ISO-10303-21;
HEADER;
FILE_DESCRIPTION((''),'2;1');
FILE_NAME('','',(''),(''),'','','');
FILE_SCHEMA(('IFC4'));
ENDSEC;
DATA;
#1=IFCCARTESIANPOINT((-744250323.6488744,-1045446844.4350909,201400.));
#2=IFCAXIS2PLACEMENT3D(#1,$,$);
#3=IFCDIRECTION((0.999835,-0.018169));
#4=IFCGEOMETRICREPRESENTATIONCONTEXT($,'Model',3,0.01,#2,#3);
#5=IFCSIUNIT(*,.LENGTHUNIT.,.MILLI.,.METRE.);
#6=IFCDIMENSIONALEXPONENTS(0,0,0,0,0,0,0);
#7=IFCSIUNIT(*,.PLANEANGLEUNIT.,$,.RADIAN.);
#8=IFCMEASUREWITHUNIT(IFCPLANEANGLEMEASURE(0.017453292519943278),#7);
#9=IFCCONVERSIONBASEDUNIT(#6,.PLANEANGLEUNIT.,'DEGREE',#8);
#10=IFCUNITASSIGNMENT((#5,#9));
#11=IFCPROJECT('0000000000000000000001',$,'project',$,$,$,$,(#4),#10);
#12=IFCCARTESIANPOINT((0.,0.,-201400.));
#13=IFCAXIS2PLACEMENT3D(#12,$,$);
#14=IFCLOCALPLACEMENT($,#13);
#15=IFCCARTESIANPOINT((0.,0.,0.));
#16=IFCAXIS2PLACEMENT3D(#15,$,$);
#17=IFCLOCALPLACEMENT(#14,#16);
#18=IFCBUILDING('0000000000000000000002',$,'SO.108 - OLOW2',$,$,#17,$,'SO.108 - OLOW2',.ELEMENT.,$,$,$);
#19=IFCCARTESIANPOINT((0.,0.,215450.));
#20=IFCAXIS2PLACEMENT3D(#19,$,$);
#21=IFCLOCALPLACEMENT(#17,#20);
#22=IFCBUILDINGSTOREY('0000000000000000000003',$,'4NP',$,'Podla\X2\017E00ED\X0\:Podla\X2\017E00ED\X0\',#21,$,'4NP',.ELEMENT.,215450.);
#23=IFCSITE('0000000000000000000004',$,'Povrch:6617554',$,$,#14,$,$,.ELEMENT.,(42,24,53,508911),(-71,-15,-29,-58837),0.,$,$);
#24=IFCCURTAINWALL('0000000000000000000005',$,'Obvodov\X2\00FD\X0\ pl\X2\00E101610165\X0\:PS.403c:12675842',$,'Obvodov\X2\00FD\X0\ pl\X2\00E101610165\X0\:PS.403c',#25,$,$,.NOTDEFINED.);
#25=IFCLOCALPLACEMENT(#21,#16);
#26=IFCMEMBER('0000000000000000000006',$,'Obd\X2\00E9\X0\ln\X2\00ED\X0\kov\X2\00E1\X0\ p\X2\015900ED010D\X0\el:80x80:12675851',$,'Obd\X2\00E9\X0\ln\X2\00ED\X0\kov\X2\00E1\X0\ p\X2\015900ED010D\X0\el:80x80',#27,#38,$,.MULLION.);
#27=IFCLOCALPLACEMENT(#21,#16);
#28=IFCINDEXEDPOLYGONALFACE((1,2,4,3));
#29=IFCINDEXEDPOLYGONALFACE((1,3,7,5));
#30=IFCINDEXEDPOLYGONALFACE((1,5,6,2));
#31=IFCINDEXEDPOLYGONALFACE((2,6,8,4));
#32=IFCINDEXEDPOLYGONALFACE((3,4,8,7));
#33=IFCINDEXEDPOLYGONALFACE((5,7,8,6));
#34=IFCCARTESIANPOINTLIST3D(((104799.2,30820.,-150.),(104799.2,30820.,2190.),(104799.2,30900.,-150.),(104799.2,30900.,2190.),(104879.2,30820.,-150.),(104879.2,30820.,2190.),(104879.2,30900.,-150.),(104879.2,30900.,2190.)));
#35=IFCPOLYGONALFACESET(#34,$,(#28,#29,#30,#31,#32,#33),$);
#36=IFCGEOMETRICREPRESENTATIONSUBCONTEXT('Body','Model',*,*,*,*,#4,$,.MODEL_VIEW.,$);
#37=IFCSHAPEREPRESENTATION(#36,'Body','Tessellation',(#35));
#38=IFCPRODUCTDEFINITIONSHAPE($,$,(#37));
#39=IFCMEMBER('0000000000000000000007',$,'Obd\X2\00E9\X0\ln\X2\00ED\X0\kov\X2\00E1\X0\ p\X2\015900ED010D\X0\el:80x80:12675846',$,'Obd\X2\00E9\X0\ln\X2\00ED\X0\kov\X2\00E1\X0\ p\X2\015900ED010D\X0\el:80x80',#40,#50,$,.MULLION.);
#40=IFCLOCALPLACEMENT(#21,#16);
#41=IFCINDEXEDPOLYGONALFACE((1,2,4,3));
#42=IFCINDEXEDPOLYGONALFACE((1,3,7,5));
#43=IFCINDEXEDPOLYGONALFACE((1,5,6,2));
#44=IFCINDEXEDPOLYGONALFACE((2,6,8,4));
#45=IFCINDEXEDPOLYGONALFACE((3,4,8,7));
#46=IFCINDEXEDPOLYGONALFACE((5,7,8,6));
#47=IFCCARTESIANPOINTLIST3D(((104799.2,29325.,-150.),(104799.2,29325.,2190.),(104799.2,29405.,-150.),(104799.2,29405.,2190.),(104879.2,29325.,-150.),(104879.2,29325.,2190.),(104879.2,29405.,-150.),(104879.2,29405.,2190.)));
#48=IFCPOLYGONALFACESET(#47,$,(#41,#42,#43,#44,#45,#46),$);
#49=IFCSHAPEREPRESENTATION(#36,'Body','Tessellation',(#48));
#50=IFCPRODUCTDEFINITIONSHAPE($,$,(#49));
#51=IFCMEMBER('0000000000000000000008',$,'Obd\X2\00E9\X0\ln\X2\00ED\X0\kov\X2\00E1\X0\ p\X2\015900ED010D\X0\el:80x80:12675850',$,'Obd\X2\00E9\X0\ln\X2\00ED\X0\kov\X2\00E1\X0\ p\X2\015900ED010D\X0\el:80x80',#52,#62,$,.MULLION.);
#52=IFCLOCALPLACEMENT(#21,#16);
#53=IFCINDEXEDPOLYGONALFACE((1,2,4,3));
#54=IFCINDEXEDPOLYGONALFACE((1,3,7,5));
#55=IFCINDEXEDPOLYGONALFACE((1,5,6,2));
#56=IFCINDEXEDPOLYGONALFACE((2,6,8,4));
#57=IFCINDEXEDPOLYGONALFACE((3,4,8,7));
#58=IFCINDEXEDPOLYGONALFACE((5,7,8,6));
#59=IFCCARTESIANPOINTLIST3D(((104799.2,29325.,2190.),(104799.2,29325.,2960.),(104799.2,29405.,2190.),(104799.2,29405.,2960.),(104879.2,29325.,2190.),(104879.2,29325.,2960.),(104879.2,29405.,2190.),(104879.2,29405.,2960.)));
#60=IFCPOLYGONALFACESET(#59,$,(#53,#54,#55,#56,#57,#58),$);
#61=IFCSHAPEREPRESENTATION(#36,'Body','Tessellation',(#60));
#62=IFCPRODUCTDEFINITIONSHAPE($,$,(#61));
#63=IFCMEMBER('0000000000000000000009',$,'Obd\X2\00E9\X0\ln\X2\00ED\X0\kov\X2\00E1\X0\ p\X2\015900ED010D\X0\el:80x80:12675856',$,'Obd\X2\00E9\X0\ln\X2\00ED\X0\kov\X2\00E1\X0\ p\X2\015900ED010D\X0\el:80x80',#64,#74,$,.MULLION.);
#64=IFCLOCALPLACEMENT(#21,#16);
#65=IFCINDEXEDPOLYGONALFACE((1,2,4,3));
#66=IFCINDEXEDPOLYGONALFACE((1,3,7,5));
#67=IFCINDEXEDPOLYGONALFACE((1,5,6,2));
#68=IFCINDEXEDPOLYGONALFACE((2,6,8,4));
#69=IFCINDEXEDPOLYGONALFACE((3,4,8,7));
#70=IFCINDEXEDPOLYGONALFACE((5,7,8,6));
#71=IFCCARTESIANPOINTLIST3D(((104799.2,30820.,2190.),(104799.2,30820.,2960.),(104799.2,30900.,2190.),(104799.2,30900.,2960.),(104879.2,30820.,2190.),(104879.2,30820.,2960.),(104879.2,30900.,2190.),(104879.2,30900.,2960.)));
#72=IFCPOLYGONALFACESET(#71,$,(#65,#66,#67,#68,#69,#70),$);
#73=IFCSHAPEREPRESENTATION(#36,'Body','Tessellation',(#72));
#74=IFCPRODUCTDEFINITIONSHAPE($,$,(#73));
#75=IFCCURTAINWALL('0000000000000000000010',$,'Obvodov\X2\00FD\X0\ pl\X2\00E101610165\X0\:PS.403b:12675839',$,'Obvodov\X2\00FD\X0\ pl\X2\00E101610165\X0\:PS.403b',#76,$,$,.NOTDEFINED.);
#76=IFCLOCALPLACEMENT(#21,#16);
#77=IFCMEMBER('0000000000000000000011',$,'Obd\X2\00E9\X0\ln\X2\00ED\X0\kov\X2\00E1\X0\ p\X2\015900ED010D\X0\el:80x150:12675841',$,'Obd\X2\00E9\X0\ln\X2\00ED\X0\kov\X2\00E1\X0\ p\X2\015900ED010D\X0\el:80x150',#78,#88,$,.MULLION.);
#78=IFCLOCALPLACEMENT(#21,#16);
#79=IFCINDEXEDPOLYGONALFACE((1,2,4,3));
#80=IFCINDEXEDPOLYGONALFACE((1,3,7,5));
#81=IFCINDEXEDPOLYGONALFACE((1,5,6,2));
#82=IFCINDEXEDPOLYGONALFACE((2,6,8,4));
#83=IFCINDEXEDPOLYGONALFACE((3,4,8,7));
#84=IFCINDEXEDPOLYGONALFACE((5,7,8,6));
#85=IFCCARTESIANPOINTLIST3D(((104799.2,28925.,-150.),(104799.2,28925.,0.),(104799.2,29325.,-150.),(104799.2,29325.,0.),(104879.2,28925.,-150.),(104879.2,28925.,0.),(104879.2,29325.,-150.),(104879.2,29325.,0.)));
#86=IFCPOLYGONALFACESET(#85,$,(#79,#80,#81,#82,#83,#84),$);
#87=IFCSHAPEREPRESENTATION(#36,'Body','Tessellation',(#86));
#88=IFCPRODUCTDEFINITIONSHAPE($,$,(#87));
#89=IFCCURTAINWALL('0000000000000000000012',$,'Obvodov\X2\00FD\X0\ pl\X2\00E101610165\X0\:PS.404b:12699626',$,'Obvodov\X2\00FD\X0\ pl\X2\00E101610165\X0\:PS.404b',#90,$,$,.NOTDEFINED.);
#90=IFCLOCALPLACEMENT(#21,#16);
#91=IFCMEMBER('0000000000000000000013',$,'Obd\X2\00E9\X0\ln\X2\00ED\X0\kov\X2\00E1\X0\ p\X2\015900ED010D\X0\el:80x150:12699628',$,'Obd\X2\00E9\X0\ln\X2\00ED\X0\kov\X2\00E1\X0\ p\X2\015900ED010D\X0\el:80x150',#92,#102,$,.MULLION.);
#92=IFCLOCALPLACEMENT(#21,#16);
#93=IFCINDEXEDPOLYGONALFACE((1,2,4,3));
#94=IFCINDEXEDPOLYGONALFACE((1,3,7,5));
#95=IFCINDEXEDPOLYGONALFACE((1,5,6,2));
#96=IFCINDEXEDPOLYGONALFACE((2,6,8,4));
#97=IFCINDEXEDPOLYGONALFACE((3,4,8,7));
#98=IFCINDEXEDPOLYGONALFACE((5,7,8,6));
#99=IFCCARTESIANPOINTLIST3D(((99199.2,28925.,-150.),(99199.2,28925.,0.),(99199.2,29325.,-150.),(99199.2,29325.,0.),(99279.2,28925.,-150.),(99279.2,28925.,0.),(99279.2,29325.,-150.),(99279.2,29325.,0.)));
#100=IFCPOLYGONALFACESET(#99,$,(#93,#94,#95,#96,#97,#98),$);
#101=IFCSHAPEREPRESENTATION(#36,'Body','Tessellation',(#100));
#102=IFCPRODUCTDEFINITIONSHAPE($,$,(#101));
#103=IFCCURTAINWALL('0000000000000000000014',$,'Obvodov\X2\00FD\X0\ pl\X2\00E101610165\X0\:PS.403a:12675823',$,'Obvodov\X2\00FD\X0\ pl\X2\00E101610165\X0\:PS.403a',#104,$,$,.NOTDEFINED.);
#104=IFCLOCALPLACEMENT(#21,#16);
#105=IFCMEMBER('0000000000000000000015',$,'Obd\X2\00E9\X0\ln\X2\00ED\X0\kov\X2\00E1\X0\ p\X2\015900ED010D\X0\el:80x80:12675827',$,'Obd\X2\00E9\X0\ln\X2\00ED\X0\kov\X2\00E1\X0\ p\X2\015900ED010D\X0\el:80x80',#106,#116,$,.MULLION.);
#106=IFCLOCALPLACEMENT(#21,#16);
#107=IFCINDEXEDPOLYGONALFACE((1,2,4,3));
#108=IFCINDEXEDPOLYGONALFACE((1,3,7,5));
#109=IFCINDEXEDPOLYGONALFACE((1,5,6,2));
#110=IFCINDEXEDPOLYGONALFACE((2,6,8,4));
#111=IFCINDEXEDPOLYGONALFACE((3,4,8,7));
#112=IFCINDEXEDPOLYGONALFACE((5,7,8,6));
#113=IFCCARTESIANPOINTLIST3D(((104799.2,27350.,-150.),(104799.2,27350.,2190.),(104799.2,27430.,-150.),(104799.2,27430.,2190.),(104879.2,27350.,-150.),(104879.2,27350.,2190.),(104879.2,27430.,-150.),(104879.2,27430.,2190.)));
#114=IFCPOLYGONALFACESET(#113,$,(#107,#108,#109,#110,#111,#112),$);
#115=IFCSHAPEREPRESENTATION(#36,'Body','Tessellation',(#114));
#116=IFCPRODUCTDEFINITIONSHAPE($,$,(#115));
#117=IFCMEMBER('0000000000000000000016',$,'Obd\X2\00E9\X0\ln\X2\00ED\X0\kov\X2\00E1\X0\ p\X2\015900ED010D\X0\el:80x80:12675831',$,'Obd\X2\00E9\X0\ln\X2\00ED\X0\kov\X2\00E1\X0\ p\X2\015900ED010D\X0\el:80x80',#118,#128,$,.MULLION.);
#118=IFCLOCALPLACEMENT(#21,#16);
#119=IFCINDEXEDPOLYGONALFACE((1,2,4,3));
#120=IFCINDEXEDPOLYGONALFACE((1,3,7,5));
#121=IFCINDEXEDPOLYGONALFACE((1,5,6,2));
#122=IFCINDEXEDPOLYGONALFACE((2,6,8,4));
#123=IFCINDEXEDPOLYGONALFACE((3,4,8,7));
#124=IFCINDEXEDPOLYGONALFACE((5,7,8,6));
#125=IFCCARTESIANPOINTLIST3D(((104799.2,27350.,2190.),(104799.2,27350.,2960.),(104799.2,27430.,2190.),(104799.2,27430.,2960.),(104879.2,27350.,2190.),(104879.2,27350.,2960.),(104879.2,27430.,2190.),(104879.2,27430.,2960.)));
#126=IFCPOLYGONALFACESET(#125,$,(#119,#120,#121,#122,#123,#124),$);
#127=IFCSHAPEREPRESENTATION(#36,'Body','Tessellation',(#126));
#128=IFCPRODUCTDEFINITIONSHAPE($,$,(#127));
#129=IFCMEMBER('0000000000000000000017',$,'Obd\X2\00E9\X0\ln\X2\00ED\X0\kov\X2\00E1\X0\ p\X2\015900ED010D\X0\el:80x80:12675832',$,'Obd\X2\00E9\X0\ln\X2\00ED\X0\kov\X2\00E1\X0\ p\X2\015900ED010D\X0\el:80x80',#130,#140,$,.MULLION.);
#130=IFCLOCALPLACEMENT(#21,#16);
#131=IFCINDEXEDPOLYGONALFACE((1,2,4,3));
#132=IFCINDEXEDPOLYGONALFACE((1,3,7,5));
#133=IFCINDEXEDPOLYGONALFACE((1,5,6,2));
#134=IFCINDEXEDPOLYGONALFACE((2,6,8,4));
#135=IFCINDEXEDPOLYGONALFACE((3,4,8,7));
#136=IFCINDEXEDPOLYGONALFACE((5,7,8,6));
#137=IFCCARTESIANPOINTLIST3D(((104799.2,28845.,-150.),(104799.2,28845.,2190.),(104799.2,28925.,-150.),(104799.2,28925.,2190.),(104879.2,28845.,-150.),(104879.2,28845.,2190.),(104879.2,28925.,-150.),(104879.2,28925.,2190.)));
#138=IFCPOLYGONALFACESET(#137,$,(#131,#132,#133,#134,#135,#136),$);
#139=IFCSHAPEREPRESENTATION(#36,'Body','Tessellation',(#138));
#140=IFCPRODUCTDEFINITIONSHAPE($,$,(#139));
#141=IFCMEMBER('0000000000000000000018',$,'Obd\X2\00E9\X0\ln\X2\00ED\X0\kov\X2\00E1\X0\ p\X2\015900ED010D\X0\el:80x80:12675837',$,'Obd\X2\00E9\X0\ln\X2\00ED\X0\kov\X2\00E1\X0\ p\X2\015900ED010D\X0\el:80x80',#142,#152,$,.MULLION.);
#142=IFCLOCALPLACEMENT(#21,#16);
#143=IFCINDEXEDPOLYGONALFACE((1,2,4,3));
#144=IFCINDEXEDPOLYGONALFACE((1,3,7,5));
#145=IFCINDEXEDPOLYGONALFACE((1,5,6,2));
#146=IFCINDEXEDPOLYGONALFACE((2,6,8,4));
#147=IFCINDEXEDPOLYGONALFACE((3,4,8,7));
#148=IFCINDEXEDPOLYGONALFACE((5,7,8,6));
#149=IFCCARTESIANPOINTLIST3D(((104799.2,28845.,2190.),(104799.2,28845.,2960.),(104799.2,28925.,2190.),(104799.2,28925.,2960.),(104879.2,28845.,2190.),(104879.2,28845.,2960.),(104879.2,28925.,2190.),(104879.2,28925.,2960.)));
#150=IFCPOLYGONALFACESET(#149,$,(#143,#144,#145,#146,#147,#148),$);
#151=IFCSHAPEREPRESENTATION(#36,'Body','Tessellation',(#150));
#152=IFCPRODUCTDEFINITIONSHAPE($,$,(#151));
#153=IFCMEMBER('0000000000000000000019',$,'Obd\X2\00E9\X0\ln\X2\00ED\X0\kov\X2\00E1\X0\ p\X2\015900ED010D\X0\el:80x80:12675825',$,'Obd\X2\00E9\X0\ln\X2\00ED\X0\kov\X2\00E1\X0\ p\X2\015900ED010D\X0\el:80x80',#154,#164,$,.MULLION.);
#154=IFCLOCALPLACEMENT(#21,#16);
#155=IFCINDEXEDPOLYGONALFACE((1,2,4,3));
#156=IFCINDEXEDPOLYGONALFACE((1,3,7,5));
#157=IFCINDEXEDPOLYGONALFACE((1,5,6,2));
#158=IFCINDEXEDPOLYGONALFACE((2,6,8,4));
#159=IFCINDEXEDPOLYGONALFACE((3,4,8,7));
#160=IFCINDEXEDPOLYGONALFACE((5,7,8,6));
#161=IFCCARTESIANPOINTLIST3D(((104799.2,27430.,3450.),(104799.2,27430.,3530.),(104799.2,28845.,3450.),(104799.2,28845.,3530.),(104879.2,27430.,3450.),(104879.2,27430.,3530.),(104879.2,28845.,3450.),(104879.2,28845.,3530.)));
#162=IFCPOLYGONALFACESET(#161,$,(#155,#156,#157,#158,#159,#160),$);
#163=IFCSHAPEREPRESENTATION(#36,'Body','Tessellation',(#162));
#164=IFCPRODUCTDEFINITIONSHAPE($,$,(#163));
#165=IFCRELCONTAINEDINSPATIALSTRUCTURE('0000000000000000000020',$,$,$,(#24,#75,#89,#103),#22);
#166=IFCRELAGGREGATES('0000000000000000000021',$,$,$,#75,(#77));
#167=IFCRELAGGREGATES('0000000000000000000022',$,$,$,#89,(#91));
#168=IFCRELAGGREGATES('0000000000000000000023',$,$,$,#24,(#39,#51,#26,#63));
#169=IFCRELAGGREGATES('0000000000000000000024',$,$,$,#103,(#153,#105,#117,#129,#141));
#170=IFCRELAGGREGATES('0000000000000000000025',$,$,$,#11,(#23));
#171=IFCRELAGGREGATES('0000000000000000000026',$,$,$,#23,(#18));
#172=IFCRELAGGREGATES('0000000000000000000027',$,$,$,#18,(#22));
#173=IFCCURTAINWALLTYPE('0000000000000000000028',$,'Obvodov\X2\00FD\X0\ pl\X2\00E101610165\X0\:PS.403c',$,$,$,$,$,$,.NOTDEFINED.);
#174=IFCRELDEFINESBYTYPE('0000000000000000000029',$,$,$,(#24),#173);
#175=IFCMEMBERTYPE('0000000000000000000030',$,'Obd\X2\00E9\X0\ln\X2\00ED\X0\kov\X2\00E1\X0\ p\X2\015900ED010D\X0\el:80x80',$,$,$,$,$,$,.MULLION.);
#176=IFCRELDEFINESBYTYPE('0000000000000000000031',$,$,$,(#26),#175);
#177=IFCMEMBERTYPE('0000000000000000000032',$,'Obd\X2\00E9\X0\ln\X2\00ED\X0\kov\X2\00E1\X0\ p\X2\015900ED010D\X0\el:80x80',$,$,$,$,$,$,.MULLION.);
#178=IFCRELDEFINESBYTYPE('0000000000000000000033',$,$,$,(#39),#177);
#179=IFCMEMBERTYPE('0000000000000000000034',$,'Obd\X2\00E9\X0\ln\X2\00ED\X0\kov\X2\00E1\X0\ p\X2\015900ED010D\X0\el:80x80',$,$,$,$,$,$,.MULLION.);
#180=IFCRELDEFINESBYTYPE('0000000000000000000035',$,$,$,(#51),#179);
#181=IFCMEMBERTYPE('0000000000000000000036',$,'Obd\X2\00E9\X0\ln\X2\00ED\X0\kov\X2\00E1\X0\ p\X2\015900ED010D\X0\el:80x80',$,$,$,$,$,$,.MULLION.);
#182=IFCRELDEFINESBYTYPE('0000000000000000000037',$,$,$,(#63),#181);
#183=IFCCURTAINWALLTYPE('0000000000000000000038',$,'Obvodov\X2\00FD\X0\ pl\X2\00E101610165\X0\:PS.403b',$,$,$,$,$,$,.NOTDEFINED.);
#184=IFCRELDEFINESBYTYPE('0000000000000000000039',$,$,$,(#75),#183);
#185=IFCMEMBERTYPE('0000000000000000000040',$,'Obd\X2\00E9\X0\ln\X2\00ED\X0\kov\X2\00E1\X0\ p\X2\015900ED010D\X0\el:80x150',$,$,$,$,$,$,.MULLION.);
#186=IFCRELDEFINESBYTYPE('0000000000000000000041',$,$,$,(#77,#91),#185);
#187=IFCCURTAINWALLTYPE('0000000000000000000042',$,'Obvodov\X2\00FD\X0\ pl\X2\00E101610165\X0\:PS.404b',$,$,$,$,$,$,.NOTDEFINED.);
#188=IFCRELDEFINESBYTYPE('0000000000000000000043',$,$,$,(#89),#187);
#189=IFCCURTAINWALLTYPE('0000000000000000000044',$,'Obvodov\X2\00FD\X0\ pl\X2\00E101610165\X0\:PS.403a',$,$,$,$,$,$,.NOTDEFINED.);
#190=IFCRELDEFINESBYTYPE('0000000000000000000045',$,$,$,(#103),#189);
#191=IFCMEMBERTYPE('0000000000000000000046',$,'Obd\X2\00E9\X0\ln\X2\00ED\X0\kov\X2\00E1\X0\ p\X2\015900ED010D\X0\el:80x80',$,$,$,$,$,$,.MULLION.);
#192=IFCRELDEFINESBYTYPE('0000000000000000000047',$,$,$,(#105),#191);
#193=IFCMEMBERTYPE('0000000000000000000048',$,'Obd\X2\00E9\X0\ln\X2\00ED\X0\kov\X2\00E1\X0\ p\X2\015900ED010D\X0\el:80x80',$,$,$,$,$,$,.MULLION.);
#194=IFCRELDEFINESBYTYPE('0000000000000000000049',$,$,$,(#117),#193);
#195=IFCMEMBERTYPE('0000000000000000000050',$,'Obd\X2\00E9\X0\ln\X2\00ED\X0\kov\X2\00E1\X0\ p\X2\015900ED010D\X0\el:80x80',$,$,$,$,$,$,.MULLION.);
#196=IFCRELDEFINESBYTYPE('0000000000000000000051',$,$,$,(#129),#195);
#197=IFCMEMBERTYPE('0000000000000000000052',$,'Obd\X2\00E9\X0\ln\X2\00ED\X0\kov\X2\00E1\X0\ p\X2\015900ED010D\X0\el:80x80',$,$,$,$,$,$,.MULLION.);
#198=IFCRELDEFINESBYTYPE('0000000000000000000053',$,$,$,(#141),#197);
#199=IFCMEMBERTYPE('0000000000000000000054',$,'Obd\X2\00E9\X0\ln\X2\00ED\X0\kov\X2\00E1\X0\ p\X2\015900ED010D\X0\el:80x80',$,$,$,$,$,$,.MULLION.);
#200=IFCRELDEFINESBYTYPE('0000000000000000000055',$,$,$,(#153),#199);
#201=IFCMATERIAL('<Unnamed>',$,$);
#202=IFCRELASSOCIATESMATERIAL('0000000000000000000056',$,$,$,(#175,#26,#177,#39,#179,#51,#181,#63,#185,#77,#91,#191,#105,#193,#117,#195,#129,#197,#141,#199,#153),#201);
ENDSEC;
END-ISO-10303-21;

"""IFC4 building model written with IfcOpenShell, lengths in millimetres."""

from ifc_helpers import new_model, entity, si_unit, converted_unit, direction, frame, origin, place, context, subcontext, project, spatial, indexed_curve, outline, extrude, source, transform, mapped, material, type_object, type_shapes, element, aggregate, save


model = new_model("IFC4")

# Units and contexts
model_context = context("Model", 3, precision=0.01, world=frame((-744250323.6488744, -1045446844.4350909, 201400.0)), true_north=direction((0.999835, -0.018169)))
body_context = subcontext(model_context, "Body", "Model", "MODEL_VIEW")
ifc_project = project(units=[si_unit("LENGTHUNIT", "METRE", prefix="MILLI"), converted_unit("PLANEANGLEUNIT", "DEGREE", entity("IfcPlaneAngleMeasure", 0.017453292519943278), si_unit("PLANEANGLEUNIT", "RADIAN"), dimensions=[0, 0, 0, 0, 0, 0, 0])], contexts=[model_context])

# Site, building, storey
site_placement = place(None, frame((0.0, 0.0, -201400.0)))
site = spatial("IfcSite", under=ifc_project, at=site_placement, Name="Povrch:6617554", CompositionType="ELEMENT", RefLatitude=(42, 24, 53, 508911), RefLongitude=(-71, -15, -29, -58837), RefElevation=0.0)
building_placement = place(site_placement, origin())
building = spatial("IfcBuilding", under=site, at=building_placement, Name="SO.108 - OLOW2", LongName="SO.108 - OLOW2", CompositionType="ELEMENT")
storey_placement = place(building_placement, frame((0.0, 0.0, 215450.0)))
storey = spatial("IfcBuildingStorey", under=building, at=storey_placement, Name="4NP", ObjectType="Podlaží:Podlaží", LongName="4NP", CompositionType="ELEMENT", Elevation=215450.0)

# Curtain wall, members
curtain_wall_type_1 = type_object("IfcCurtainWallType", Name="Obvodový plášť:PS.403c", PredefinedType="NOTDEFINED")
curtain_wall_1_placement = place(storey_placement, frame((0.0, 0.0, -215450.0)))
curtain_wall_1 = element("IfcCurtainWall", 1, at=curtain_wall_1_placement, inside=storey, type_object=curtain_wall_type_1, Name="Obvodový plášť:PS.403c:12675842", ObjectType="Obvodový plášť:PS.403c", PredefinedType="NOTDEFINED")
ifc_material_1 = material(Name="<Unnamed>")
member_type_1 = type_object("IfcMemberType", Name="Obdélníková příčel:80x80", PredefinedType="MULLION", material=ifc_material_1)
shared_shape_1 = source(origin(), body_context, "Body", "SweptSolid", [
    extrude(outline(indexed_curve([(-40.0, -40.0), (40.0, -40.0), (40.0, 40.0), (-40.0, 40.0), (-40.0, -40.0)], self_intersect=False)), frame((-40.0, 0.0, -2340.0), z_axis=(0.0, 0.0, 1.0), x_axis=(-1.0, 0.0, 0.0)), (0.0, 0.0, 1.0), 2340.0),
])
type_shapes(member_type_1, [shared_shape_1])
member_1_placement = place(curtain_wall_1_placement, frame((104839.2, 30900.0, 217640.0), z_axis=(0.0, 0.0, 1.0), x_axis=(0.0, 1.0, 0.0)))
member_1 = element("IfcMember", 2, at=member_1_placement, type_object=member_type_1, material=ifc_material_1, Name="Obdélníková příčel:80x80:12675851", ObjectType="Obdélníková příčel:80x80", PredefinedType="MULLION", context=body_context, shape_type="MappedRepresentation", body=[
    mapped(shared_shape_1, transform((0.0, 0.0, 0.0), scale=1.0)),
])
member_type_2 = type_object("IfcMemberType", Name="Obdélníková příčel:80x80", PredefinedType="MULLION", material=ifc_material_1)
shared_shape_2 = source(origin(), body_context, "Body", "SweptSolid", [
    extrude(outline(indexed_curve([(-40.0, -40.0), (40.0, -40.0), (40.0, 40.0), (-40.0, 40.0), (-40.0, -40.0)], self_intersect=False)), frame((-40.0, 0.0, -2340.0), z_axis=(0.0, 0.0, 1.0), x_axis=(-1.0, 0.0, 0.0)), (0.0, 0.0, 1.0), 2340.0),
])
type_shapes(member_type_2, [shared_shape_2])
member_2_placement = place(curtain_wall_1_placement, frame((104839.2, 29325.0, 215300.0), z_axis=(0.0, 0.0, -1.0), x_axis=(0.0, -1.0, 0.0)))
member_2 = element("IfcMember", 3, at=member_2_placement, type_object=member_type_2, material=ifc_material_1, Name="Obdélníková příčel:80x80:12675846", ObjectType="Obdélníková příčel:80x80", PredefinedType="MULLION", context=body_context, shape_type="MappedRepresentation", body=[
    mapped(shared_shape_2, transform((0.0, 0.0, 0.0), scale=1.0)),
])
member_type_3 = type_object("IfcMemberType", Name="Obdélníková příčel:80x80", PredefinedType="MULLION", material=ifc_material_1)
shared_shape_3 = source(origin(), body_context, "Body", "SweptSolid", [
    extrude(outline(indexed_curve([(-40.0, -40.0), (40.0, -40.0), (40.0, 40.0), (-40.0, 40.0), (-40.0, -40.0)], self_intersect=False)), frame((-40.0, 0.0, -770.0), z_axis=(0.0, 0.0, 1.0), x_axis=(-1.0, 0.0, 0.0)), (0.0, 0.0, 1.0), 770.0),
])
type_shapes(member_type_3, [shared_shape_3])
member_3_placement = place(curtain_wall_1_placement, frame((104839.2, 29325.0, 217640.0), z_axis=(0.0, 0.0, -1.0), x_axis=(0.0, -1.0, 0.0)))
member_3 = element("IfcMember", 4, at=member_3_placement, type_object=member_type_3, material=ifc_material_1, Name="Obdélníková příčel:80x80:12675850", ObjectType="Obdélníková příčel:80x80", PredefinedType="MULLION", context=body_context, shape_type="MappedRepresentation", body=[
    mapped(shared_shape_3, transform((0.0, 0.0, 0.0), scale=1.0)),
])
member_type_4 = type_object("IfcMemberType", Name="Obdélníková příčel:80x80", PredefinedType="MULLION", material=ifc_material_1)
shared_shape_4 = source(origin(), body_context, "Body", "SweptSolid", [
    extrude(outline(indexed_curve([(-40.0, -40.0), (40.0, -40.0), (40.0, 40.0), (-40.0, 40.0), (-40.0, -40.0)], self_intersect=False)), frame((-40.0, 0.0, -770.0), z_axis=(0.0, 0.0, 1.0), x_axis=(-1.0, 0.0, 0.0)), (0.0, 0.0, 1.0), 770.0),
])
type_shapes(member_type_4, [shared_shape_4])
member_4_placement = place(curtain_wall_1_placement, frame((104839.2, 30900.0, 218410.0), z_axis=(0.0, 0.0, 1.0), x_axis=(0.0, 1.0, 0.0)))
member_4 = element("IfcMember", 5, at=member_4_placement, type_object=member_type_4, material=ifc_material_1, Name="Obdélníková příčel:80x80:12675856", ObjectType="Obdélníková příčel:80x80", PredefinedType="MULLION", context=body_context, shape_type="MappedRepresentation", body=[
    mapped(shared_shape_4, transform((0.0, 0.0, 0.0), scale=1.0)),
])

# Curtain walls, members
curtain_wall_type_2 = type_object("IfcCurtainWallType", Name="Obvodový plášť:PS.403b", PredefinedType="NOTDEFINED")
curtain_wall_2_placement = place(storey_placement, frame((0.0, 0.0, -215450.0)))
curtain_wall_2 = element("IfcCurtainWall", 6, at=curtain_wall_2_placement, inside=storey, type_object=curtain_wall_type_2, Name="Obvodový plášť:PS.403b:12675839", ObjectType="Obvodový plášť:PS.403b", PredefinedType="NOTDEFINED")
member_type_5 = type_object("IfcMemberType", Name="Obdélníková příčel:80x150", PredefinedType="MULLION", material=ifc_material_1)
shared_shape_5 = source(origin(), body_context, "Body", "SweptSolid", [
    extrude(outline(indexed_curve([(-75.0, -40.0), (75.0, -40.0), (75.0, 40.0), (-75.0, 40.0), (-75.0, -40.0)], self_intersect=False)), frame((-75.0, 0.0, -400.0), z_axis=(0.0, 0.0, 1.0), x_axis=(-1.0, 0.0, 0.0)), (0.0, 0.0, 1.0), 400.0),
])
type_shapes(member_type_5, [shared_shape_5])
member_5_placement = place(curtain_wall_2_placement, frame((104839.2, 28925.0, 215300.0), z_axis=(0.0, -1.0, 0.0), x_axis=(0.0, 0.0, -1.0)))
member_5 = element("IfcMember", 7, at=member_5_placement, type_object=member_type_5, material=ifc_material_1, Name="Obdélníková příčel:80x150:12675841", ObjectType="Obdélníková příčel:80x150", PredefinedType="MULLION", context=body_context, shape_type="MappedRepresentation", body=[
    mapped(shared_shape_5, transform((0.0, 0.0, 0.0), scale=1.0)),
])
curtain_wall_type_3 = type_object("IfcCurtainWallType", Name="Obvodový plášť:PS.404b", PredefinedType="NOTDEFINED")
curtain_wall_3_placement = place(storey_placement, frame((0.0, 0.0, -215450.0)))
curtain_wall_3 = element("IfcCurtainWall", 8, at=curtain_wall_3_placement, inside=storey, type_object=curtain_wall_type_3, Name="Obvodový plášť:PS.404b:12699626", ObjectType="Obvodový plášť:PS.404b", PredefinedType="NOTDEFINED")
member_6_placement = place(curtain_wall_3_placement, frame((99239.2, 28925.0, 215300.0), z_axis=(0.0, -1.0, 0.0), x_axis=(0.0, 0.0, -1.0)))
member_6 = element("IfcMember", 9, at=member_6_placement, type_object=member_type_5, material=ifc_material_1, Name="Obdélníková příčel:80x150:12699628", ObjectType="Obdélníková příčel:80x150", PredefinedType="MULLION", context=body_context, shape_type="MappedRepresentation", body=[
    mapped(shared_shape_5, transform((0.0, 0.0, 0.0), scale=1.0)),
])

# Curtain wall, members
curtain_wall_type_4 = type_object("IfcCurtainWallType", Name="Obvodový plášť:PS.403a", PredefinedType="NOTDEFINED")
curtain_wall_4_placement = place(storey_placement, frame((0.0, 0.0, -215450.0)))
curtain_wall_4 = element("IfcCurtainWall", 10, at=curtain_wall_4_placement, inside=storey, type_object=curtain_wall_type_4, Name="Obvodový plášť:PS.403a:12675823", ObjectType="Obvodový plášť:PS.403a", PredefinedType="NOTDEFINED")
member_type_6 = type_object("IfcMemberType", Name="Obdélníková příčel:80x80", PredefinedType="MULLION", material=ifc_material_1)
shared_shape_6 = source(origin(), body_context, "Body", "SweptSolid", [
    extrude(outline(indexed_curve([(-40.0, -40.0), (40.0, -40.0), (40.0, 40.0), (-40.0, 40.0), (-40.0, -40.0)], self_intersect=False)), frame((-40.0, 0.0, -2340.0), z_axis=(0.0, 0.0, 1.0), x_axis=(-1.0, 0.0, 0.0)), (0.0, 0.0, 1.0), 2340.0),
])
type_shapes(member_type_6, [shared_shape_6])
member_7_placement = place(curtain_wall_4_placement, frame((104839.2, 27350.0, 215300.0), z_axis=(0.0, 0.0, -1.0), x_axis=(0.0, -1.0, 0.0)))
member_7 = element("IfcMember", 11, at=member_7_placement, type_object=member_type_6, material=ifc_material_1, Name="Obdélníková příčel:80x80:12675827", ObjectType="Obdélníková příčel:80x80", PredefinedType="MULLION", context=body_context, shape_type="MappedRepresentation", body=[
    mapped(shared_shape_6, transform((0.0, 0.0, 0.0), scale=1.0)),
])
member_type_7 = type_object("IfcMemberType", Name="Obdélníková příčel:80x80", PredefinedType="MULLION", material=ifc_material_1)
shared_shape_7 = source(origin(), body_context, "Body", "SweptSolid", [
    extrude(outline(indexed_curve([(-40.0, -40.0), (40.0, -40.0), (40.0, 40.0), (-40.0, 40.0), (-40.0, -40.0)], self_intersect=False)), frame((-40.0, 0.0, -770.0), z_axis=(0.0, 0.0, 1.0), x_axis=(-1.0, 0.0, 0.0)), (0.0, 0.0, 1.0), 770.0),
])
type_shapes(member_type_7, [shared_shape_7])
member_8_placement = place(curtain_wall_4_placement, frame((104839.2, 27350.0, 217640.0), z_axis=(0.0, 0.0, -1.0), x_axis=(0.0, -1.0, 0.0)))
member_8 = element("IfcMember", 12, at=member_8_placement, type_object=member_type_7, material=ifc_material_1, Name="Obdélníková příčel:80x80:12675831", ObjectType="Obdélníková příčel:80x80", PredefinedType="MULLION", context=body_context, shape_type="MappedRepresentation", body=[
    mapped(shared_shape_7, transform((0.0, 0.0, 0.0), scale=1.0)),
])
member_type_8 = type_object("IfcMemberType", Name="Obdélníková příčel:80x80", PredefinedType="MULLION", material=ifc_material_1)
shared_shape_8 = source(origin(), body_context, "Body", "SweptSolid", [
    extrude(outline(indexed_curve([(-40.0, -40.0), (40.0, -40.0), (40.0, 40.0), (-40.0, 40.0), (-40.0, -40.0)], self_intersect=False)), frame((-40.0, 0.0, -2340.0), z_axis=(0.0, 0.0, 1.0), x_axis=(-1.0, 0.0, 0.0)), (0.0, 0.0, 1.0), 2340.0),
])
type_shapes(member_type_8, [shared_shape_8])
member_9_placement = place(curtain_wall_4_placement, frame((104839.2, 28925.0, 217640.0), z_axis=(0.0, 0.0, 1.0), x_axis=(0.0, 1.0, 0.0)))
member_9 = element("IfcMember", 13, at=member_9_placement, type_object=member_type_8, material=ifc_material_1, Name="Obdélníková příčel:80x80:12675832", ObjectType="Obdélníková příčel:80x80", PredefinedType="MULLION", context=body_context, shape_type="MappedRepresentation", body=[
    mapped(shared_shape_8, transform((0.0, 0.0, 0.0), scale=1.0)),
])
member_type_9 = type_object("IfcMemberType", Name="Obdélníková příčel:80x80", PredefinedType="MULLION", material=ifc_material_1)
shared_shape_9 = source(origin(), body_context, "Body", "SweptSolid", [
    extrude(outline(indexed_curve([(-40.0, -40.0), (40.0, -40.0), (40.0, 40.0), (-40.0, 40.0), (-40.0, -40.0)], self_intersect=False)), frame((-40.0, 0.0, -770.0), z_axis=(0.0, 0.0, 1.0), x_axis=(-1.0, 0.0, 0.0)), (0.0, 0.0, 1.0), 770.0),
])
type_shapes(member_type_9, [shared_shape_9])
member_10_placement = place(curtain_wall_4_placement, frame((104839.2, 28925.0, 218410.0), z_axis=(0.0, 0.0, 1.0), x_axis=(0.0, 1.0, 0.0)))
member_10 = element("IfcMember", 14, at=member_10_placement, type_object=member_type_9, material=ifc_material_1, Name="Obdélníková příčel:80x80:12675837", ObjectType="Obdélníková příčel:80x80", PredefinedType="MULLION", context=body_context, shape_type="MappedRepresentation", body=[
    mapped(shared_shape_9, transform((0.0, 0.0, 0.0), scale=1.0)),
])
member_type_10 = type_object("IfcMemberType", Name="Obdélníková příčel:80x80", PredefinedType="MULLION", material=ifc_material_1)
shared_shape_10 = source(origin(), body_context, "Body", "SweptSolid", [
    extrude(outline(indexed_curve([(-40.0, -40.0), (40.0, -40.0), (40.0, 40.0), (-40.0, 40.0), (-40.0, -40.0)], self_intersect=False)), frame((-40.0, 0.0, -1415.0), z_axis=(0.0, 0.0, 1.0), x_axis=(-1.0, 0.0, 0.0)), (0.0, 0.0, 1.0), 1415.0),
])
type_shapes(member_type_10, [shared_shape_10])
member_11_placement = place(curtain_wall_4_placement, frame((104839.2, 27430.0, 218980.0), z_axis=(0.0, -1.0, 0.0), x_axis=(0.0, 0.0, 1.0)))
member_11 = element("IfcMember", 15, at=member_11_placement, type_object=member_type_10, material=ifc_material_1, Name="Obdélníková příčel:80x80:12675825", ObjectType="Obdélníková příčel:80x80", PredefinedType="MULLION", context=body_context, shape_type="MappedRepresentation", body=[
    mapped(shared_shape_10, transform((0.0, 0.0, 0.0), scale=1.0)),
])

aggregate(curtain_wall_2, [member_5])
aggregate(curtain_wall_3, [member_6])
aggregate(curtain_wall_1, [member_2, member_3, member_1, member_4])

aggregate(curtain_wall_4, [member_11, member_7, member_8, member_9, member_10])

save(model, "model.ifc")
